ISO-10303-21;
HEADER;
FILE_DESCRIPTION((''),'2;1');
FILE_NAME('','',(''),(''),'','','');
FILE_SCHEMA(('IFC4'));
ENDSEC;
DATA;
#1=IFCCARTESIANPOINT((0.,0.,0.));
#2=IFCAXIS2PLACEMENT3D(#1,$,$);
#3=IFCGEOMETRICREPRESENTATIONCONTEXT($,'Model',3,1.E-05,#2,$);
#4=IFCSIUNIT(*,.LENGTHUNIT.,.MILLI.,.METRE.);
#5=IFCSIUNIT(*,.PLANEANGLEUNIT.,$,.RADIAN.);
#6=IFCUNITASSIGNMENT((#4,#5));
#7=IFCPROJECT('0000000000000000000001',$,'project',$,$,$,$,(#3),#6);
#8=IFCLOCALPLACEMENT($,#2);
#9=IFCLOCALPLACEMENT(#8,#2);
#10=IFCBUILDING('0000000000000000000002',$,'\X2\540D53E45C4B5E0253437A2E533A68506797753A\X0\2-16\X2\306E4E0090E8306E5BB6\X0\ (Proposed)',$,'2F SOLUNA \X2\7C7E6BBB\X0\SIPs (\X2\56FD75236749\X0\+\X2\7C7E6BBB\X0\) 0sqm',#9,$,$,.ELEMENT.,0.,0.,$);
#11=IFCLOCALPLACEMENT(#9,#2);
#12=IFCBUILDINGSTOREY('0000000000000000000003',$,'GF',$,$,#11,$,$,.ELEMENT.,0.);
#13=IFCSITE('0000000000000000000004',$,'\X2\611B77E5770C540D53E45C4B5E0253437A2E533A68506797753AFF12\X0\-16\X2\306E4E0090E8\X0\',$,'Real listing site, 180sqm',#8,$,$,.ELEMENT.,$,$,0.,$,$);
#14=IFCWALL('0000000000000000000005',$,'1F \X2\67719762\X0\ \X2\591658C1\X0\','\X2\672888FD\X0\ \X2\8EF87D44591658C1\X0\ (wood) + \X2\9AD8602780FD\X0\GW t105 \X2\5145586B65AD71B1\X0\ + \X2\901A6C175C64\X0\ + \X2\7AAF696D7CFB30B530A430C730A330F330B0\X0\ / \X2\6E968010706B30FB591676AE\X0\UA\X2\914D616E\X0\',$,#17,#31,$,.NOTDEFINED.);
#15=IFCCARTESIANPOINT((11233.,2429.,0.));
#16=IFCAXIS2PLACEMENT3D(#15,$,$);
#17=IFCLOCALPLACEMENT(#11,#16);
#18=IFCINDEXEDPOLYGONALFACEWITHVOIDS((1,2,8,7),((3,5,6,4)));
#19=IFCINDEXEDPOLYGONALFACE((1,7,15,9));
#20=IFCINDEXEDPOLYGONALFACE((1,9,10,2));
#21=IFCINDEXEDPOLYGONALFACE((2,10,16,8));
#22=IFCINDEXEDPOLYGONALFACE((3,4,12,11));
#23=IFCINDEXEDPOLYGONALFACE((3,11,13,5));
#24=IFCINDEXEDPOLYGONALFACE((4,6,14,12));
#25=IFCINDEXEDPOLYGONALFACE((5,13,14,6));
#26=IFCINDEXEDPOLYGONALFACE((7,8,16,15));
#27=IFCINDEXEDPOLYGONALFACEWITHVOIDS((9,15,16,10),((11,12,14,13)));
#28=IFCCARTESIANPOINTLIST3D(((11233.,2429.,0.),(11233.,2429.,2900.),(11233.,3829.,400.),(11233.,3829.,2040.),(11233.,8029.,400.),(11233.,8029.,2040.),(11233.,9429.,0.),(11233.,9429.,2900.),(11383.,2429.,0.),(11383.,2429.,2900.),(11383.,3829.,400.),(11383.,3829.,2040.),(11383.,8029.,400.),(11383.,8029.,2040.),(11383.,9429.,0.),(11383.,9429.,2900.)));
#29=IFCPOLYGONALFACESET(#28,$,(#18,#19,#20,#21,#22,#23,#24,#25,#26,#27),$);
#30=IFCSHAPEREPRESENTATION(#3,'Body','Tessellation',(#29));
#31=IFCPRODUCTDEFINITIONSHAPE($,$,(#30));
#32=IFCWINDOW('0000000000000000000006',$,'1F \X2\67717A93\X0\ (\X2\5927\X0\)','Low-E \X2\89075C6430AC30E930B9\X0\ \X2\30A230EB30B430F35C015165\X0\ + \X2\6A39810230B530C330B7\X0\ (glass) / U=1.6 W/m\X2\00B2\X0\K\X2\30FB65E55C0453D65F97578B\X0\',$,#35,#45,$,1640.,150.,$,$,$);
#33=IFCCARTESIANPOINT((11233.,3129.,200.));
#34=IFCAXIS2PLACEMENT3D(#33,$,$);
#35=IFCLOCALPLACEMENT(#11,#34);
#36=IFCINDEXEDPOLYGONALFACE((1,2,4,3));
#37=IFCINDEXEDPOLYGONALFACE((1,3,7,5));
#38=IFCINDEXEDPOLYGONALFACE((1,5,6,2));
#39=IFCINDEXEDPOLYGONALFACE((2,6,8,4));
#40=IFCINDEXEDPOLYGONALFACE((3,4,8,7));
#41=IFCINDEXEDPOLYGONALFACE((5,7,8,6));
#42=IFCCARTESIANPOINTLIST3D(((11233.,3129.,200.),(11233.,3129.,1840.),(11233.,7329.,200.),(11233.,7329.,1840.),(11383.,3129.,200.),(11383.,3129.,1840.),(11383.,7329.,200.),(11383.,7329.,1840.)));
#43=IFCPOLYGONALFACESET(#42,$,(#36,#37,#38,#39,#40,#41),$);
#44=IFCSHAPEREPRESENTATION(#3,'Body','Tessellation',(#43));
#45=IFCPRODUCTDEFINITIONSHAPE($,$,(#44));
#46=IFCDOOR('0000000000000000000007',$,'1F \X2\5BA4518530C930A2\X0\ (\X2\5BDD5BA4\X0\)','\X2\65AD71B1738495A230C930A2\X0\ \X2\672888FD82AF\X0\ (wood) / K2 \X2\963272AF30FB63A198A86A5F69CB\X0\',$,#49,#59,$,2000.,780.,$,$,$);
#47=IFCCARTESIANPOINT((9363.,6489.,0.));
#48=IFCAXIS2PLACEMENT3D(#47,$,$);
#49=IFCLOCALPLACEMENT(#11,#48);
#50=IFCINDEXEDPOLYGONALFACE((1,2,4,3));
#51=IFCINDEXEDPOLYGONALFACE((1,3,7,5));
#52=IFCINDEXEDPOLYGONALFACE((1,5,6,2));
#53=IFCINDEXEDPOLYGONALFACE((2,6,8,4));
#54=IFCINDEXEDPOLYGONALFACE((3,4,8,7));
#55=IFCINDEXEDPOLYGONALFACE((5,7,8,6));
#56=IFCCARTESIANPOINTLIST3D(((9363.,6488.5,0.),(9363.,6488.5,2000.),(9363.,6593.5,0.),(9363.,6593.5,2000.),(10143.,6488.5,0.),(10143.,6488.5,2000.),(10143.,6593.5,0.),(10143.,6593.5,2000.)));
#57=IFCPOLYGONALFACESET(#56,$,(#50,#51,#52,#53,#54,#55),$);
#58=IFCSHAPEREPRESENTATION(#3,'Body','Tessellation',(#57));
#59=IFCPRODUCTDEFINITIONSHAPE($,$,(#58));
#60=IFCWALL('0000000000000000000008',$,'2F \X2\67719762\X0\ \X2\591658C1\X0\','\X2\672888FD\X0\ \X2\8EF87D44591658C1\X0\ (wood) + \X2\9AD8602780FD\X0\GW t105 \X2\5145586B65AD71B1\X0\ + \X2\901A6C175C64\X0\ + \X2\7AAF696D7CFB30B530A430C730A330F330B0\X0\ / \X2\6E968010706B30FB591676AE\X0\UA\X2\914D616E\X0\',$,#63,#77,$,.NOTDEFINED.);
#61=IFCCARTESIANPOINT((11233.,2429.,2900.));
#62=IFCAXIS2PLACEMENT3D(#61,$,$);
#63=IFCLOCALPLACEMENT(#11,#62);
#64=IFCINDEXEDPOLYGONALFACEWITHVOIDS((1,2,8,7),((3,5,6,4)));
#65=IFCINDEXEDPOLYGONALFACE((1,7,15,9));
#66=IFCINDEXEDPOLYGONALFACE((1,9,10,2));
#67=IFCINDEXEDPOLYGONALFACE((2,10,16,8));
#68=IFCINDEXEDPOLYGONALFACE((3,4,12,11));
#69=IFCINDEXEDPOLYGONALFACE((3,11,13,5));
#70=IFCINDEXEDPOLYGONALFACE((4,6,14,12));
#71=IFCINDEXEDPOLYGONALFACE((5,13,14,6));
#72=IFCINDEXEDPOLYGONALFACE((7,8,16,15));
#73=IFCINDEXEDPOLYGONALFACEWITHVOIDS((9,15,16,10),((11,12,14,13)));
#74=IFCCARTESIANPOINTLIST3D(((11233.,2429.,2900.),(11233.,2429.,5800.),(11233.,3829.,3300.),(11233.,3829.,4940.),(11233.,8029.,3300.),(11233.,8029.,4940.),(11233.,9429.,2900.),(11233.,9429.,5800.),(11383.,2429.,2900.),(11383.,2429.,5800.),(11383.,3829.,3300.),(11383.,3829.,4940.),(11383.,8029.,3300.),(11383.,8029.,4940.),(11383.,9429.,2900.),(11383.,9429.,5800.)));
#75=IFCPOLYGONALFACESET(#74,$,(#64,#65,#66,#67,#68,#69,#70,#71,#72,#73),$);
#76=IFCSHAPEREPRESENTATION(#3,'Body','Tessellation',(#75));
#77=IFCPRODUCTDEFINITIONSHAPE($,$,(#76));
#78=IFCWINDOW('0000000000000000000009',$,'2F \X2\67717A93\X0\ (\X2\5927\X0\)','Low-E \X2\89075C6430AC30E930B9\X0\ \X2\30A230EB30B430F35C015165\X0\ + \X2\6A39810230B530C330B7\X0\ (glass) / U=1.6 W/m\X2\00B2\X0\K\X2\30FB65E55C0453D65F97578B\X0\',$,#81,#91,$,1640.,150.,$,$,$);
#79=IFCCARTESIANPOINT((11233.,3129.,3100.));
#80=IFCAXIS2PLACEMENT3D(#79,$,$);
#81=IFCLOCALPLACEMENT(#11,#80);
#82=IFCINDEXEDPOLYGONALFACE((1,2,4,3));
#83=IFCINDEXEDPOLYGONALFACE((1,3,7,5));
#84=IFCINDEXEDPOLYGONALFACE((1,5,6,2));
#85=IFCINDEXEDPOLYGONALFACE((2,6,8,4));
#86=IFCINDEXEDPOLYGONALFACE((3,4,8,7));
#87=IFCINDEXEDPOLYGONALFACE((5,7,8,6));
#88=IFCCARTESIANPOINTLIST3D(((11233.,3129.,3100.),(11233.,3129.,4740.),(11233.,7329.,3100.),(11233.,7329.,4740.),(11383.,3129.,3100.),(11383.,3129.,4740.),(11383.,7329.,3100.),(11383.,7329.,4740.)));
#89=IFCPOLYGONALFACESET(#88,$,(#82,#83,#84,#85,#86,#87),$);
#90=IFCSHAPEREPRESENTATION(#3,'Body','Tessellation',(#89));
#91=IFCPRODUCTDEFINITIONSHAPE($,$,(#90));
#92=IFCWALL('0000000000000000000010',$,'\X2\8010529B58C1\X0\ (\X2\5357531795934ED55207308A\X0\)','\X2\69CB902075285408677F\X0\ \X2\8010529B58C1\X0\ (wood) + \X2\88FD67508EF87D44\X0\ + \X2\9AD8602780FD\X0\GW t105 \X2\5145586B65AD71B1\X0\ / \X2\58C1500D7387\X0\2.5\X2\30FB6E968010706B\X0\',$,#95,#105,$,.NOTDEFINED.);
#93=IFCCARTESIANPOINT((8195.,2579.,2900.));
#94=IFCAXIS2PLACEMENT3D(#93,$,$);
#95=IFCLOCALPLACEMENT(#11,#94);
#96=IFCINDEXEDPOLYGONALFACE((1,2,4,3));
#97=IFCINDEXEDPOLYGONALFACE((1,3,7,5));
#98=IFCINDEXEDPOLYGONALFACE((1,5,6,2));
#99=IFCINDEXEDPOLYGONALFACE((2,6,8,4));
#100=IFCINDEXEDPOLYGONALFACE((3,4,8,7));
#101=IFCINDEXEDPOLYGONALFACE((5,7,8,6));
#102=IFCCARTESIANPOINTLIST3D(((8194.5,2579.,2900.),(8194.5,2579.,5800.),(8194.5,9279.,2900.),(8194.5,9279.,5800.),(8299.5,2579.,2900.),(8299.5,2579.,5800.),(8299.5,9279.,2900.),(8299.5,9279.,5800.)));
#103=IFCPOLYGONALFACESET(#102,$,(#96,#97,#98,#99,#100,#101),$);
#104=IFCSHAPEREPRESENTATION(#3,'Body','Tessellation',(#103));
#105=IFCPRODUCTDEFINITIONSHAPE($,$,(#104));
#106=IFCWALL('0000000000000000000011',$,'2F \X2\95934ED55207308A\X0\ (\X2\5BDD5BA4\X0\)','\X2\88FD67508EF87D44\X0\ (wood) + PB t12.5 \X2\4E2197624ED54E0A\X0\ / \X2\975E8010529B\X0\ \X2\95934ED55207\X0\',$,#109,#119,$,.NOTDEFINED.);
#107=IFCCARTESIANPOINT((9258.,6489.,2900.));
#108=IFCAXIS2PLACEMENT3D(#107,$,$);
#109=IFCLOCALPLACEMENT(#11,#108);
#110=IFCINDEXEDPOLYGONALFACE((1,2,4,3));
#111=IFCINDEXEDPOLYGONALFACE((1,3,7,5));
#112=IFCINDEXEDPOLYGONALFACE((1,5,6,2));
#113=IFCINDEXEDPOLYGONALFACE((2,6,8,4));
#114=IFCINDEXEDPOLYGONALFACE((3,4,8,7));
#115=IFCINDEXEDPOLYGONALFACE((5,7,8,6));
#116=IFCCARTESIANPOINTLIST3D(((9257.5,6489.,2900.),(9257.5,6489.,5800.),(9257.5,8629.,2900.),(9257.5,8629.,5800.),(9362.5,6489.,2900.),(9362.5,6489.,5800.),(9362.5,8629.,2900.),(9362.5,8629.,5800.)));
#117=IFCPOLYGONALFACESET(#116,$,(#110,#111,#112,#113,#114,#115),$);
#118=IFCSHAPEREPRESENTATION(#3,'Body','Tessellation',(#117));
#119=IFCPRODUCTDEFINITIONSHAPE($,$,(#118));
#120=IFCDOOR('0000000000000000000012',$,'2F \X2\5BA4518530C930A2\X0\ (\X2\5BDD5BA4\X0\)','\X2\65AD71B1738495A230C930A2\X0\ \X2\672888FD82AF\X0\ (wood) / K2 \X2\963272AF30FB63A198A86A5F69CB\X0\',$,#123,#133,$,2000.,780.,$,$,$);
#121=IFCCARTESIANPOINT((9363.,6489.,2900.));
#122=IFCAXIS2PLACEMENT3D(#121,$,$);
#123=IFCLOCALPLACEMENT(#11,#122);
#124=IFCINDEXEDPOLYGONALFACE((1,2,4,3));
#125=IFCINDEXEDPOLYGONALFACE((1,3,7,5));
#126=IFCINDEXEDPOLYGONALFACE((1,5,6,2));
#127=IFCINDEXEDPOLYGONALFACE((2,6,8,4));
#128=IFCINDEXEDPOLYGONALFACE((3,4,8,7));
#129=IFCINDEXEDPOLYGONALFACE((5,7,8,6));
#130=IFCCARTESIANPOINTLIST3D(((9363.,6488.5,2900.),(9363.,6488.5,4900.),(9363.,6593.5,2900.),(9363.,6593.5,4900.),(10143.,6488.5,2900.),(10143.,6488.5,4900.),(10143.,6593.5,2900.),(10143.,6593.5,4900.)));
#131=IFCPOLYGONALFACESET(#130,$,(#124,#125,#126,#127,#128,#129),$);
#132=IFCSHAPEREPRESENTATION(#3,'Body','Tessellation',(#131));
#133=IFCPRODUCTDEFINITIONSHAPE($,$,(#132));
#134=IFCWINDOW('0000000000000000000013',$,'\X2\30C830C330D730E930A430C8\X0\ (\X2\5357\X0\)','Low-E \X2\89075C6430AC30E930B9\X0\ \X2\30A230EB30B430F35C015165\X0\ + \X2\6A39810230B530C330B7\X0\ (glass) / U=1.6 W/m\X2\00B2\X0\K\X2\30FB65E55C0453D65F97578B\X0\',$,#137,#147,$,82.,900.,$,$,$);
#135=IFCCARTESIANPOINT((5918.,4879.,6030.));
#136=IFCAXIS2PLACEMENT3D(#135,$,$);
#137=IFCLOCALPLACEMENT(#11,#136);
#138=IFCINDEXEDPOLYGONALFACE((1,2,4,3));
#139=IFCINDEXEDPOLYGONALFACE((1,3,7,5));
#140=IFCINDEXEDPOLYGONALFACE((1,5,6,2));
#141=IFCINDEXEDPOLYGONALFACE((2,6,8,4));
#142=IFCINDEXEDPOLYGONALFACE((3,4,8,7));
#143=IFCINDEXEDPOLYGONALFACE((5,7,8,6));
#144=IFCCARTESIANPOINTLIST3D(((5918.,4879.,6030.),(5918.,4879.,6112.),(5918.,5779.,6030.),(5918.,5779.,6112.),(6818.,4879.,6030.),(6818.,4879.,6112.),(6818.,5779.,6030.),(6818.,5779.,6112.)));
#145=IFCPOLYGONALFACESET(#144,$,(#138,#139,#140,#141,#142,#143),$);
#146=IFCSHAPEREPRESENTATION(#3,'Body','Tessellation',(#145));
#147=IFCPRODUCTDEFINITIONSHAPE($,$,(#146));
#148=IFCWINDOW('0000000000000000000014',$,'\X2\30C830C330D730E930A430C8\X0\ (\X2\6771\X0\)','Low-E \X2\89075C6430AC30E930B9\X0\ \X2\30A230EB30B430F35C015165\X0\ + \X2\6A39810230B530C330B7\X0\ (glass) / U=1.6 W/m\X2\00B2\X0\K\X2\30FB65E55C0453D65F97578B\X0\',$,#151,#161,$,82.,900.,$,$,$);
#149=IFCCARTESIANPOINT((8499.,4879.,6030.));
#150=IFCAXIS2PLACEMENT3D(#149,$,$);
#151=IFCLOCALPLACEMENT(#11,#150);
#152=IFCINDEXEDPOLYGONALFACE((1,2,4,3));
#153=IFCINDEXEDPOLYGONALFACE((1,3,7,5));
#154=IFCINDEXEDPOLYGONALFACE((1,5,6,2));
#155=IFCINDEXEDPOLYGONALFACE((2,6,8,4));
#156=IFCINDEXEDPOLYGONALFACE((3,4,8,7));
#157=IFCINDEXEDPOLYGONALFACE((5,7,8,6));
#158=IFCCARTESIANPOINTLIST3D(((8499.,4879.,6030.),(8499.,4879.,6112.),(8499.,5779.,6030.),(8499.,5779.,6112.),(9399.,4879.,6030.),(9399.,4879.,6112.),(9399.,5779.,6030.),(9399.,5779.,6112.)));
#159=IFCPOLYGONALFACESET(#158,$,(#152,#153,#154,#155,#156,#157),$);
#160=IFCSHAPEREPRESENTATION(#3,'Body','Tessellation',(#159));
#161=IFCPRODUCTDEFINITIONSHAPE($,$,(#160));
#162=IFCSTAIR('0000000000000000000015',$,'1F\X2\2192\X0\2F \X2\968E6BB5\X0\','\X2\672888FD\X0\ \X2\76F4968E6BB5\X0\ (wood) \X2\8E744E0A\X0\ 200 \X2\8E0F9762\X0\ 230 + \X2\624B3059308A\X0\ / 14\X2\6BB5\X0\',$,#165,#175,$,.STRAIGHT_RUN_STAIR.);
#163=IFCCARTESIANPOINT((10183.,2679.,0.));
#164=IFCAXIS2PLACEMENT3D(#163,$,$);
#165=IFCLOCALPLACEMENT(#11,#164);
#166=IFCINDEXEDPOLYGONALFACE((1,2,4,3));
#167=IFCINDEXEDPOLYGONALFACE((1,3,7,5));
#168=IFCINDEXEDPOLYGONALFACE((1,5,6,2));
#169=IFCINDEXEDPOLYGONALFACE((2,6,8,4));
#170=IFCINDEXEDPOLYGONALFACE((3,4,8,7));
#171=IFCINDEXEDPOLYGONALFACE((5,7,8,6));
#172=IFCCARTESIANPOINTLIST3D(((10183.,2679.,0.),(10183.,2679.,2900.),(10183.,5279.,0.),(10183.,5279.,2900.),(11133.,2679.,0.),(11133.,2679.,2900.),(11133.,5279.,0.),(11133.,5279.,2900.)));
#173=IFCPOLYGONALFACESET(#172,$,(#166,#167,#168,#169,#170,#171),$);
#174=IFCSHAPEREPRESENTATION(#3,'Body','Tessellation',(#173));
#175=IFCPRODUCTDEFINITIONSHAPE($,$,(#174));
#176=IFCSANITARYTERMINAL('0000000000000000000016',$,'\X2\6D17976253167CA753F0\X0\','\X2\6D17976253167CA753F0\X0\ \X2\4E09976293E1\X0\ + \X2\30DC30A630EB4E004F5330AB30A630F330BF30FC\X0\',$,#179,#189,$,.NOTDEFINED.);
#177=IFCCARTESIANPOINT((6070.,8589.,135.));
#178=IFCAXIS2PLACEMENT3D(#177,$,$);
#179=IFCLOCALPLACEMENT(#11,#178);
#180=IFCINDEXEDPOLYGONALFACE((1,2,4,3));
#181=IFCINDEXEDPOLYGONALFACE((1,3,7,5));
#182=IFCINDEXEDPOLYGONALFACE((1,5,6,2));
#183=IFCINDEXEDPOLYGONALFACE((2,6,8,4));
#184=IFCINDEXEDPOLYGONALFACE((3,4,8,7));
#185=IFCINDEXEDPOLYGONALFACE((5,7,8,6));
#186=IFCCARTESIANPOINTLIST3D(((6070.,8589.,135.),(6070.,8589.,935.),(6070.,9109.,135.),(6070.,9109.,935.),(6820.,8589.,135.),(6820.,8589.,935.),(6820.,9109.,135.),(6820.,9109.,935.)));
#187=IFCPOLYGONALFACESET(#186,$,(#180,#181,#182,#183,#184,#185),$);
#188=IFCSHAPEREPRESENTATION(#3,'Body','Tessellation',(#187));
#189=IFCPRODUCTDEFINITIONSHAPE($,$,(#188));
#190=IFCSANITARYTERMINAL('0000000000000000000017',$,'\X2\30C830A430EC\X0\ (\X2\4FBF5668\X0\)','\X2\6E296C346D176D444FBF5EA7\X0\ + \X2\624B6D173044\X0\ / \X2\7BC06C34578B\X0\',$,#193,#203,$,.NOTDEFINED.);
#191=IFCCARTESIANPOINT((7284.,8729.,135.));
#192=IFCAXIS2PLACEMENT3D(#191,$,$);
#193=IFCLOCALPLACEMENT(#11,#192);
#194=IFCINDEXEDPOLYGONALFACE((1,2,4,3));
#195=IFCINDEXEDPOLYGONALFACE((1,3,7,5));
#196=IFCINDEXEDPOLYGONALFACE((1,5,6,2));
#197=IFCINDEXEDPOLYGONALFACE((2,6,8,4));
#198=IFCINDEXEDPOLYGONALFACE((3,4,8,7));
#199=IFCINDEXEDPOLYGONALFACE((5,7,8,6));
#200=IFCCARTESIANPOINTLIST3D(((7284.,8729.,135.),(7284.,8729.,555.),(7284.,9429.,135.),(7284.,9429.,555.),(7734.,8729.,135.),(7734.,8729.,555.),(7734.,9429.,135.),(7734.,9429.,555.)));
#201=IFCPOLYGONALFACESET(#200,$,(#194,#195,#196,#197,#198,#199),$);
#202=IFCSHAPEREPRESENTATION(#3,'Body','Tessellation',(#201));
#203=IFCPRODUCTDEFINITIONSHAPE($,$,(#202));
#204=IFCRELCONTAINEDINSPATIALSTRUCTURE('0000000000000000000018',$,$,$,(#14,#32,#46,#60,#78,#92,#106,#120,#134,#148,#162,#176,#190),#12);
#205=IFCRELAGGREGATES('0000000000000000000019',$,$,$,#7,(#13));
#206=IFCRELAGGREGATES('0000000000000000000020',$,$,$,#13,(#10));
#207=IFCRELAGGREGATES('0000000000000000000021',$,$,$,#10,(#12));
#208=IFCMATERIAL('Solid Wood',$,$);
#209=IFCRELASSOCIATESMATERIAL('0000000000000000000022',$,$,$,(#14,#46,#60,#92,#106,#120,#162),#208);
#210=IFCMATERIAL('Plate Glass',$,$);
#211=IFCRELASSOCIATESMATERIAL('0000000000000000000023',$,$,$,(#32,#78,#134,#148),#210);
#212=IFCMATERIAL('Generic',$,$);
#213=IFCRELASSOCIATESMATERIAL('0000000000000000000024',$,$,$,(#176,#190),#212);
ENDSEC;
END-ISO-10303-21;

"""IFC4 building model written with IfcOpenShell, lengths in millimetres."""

from ifc_helpers import new_model, si_unit, frame, frame_2d, origin, place, context, project, spatial, rectangle, extrude, material, element, fill, save


model = new_model("IFC4")

# Units and contexts
model_context = context("Model", 3, precision=1e-05, world=origin())
ifc_project = project(units=[si_unit("LENGTHUNIT", "METRE", prefix="MILLI"), si_unit("PLANEANGLEUNIT", "RADIAN")], contexts=[model_context])

# Site, building, storey
site_placement = place(None, origin())
site = spatial("IfcSite", under=ifc_project, at=site_placement, Name="愛知県名古屋市千種区桐林町２-16の一部", ObjectType="Real listing site, 180sqm", CompositionType="ELEMENT", RefElevation=0.0)
building_placement = place(site_placement, origin())
building = spatial("IfcBuilding", under=site, at=building_placement, Name="名古屋市千種区桐林町2-16の一部の家 (Proposed)", ObjectType="2F SOLUNA 籾殻SIPs (国産杉+籾殻) 0sqm", CompositionType="ELEMENT", ElevationOfRefHeight=0.0, ElevationOfTerrain=0.0)
storey_placement = place(building_placement, origin())
storey = spatial("IfcBuildingStorey", under=building, at=storey_placement, Name="GF", CompositionType="ELEMENT", Elevation=0.0)

# Wall, opening, window
ifc_material_1 = material(Name="Solid Wood")
wall_1_placement = place(storey_placement, frame((11233.0, 2429.0, 0.0)))
wall_1 = element("IfcWall", 1, at=wall_1_placement, inside=storey, material=ifc_material_1, Name="1F 東面 外壁", Description="木製 軸組外壁 (wood) + 高性能GW t105 充填断熱 + 通気層 + 窯業系サイディング / 準耐火・外皮UA配慮", PredefinedType="NOTDEFINED", context=model_context, shape_type="SweptSolid", body=[
    extrude(rectangle(XDim=150.0, YDim=7000.0, at=frame_2d((75.0, 3500.0))), frame((11233.0, 2429.0, 0.0)), (0.0, 0.0, 1.0), 2900.0),
])
opening_1_placement = place(storey_placement, frame((11233.0, 3129.0, 200.0)))
opening_1 = element("IfcOpeningElement", 2, at=opening_1_placement, cuts=wall_1, PredefinedType="NOTDEFINED", context=model_context, shape_type="SweptSolid", body=[
    extrude(rectangle(XDim=150.0, YDim=4200.0, at=frame_2d((75.0, 2100.0))), frame((11233.0, 3129.0, 200.0)), (0.0, 0.0, 1.0), 1640.0),
])
ifc_material_2 = material(Name="Plate Glass")
window_1_placement = place(storey_placement, frame((11233.0, 3129.0, 200.0)))
window_1 = element("IfcWindow", 3, at=window_1_placement, inside=storey, material=ifc_material_2, Name="1F 東窓 (大)", Description="Low-E 複層ガラス アルゴン封入 + 樹脂サッシ (glass) / U=1.6 W/m²K・日射取得型", OverallHeight=1640.0, OverallWidth=150.0, context=model_context, shape_type="SweptSolid", body=[
    extrude(rectangle(XDim=150.0, YDim=4200.0, at=frame_2d((75.0, 2100.0))), frame((11233.0, 3129.0, 200.0)), (0.0, 0.0, 1.0), 1640.0),
])
fill(opening_1, window_1)

# Door
door_1_placement = place(storey_placement, frame((9363.0, 6489.0, 0.0)))
element("IfcDoor", 4, at=door_1_placement, inside=storey, material=ifc_material_1, Name="1F 室内ドア (寝室)", Description="断熱玄関ドア 木製芯 (wood) / K2 防犯・採風機構", OverallHeight=2000.0, OverallWidth=780.0, context=model_context, shape_type="SweptSolid", body=[
    extrude(rectangle(XDim=780.0, YDim=105.0, at=frame_2d((390.0, 52.0))), frame((9363.0, 6489.0, 0.0)), (0.0, 0.0, 1.0), 2000.0),
])

# Wall, opening, window
wall_2_placement = place(storey_placement, frame((11233.0, 2429.0, 2900.0)))
wall_2 = element("IfcWall", 5, at=wall_2_placement, inside=storey, material=ifc_material_1, Name="2F 東面 外壁", Description="木製 軸組外壁 (wood) + 高性能GW t105 充填断熱 + 通気層 + 窯業系サイディング / 準耐火・外皮UA配慮", PredefinedType="NOTDEFINED", context=model_context, shape_type="SweptSolid", body=[
    extrude(rectangle(XDim=150.0, YDim=7000.0, at=frame_2d((75.0, 3500.0))), frame((11233.0, 2429.0, 2900.0)), (0.0, 0.0, 1.0), 2900.0),
])
opening_2_placement = place(storey_placement, frame((11233.0, 3129.0, 3100.0)))
opening_2 = element("IfcOpeningElement", 6, at=opening_2_placement, cuts=wall_2, PredefinedType="NOTDEFINED", context=model_context, shape_type="SweptSolid", body=[
    extrude(rectangle(XDim=150.0, YDim=4200.0, at=frame_2d((75.0, 2100.0))), frame((11233.0, 3129.0, 3100.0)), (0.0, 0.0, 1.0), 1640.0),
])
window_2_placement = place(storey_placement, frame((11233.0, 3129.0, 3100.0)))
window_2 = element("IfcWindow", 7, at=window_2_placement, inside=storey, material=ifc_material_2, Name="2F 東窓 (大)", Description="Low-E 複層ガラス アルゴン封入 + 樹脂サッシ (glass) / U=1.6 W/m²K・日射取得型", OverallHeight=1640.0, OverallWidth=150.0, context=model_context, shape_type="SweptSolid", body=[
    extrude(rectangle(XDim=150.0, YDim=4200.0, at=frame_2d((75.0, 2100.0))), frame((11233.0, 3129.0, 3100.0)), (0.0, 0.0, 1.0), 1640.0),
])
fill(opening_2, window_2)

# Walls
wall_3_placement = place(storey_placement, frame((8195.0, 2579.0, 2900.0)))
element("IfcWall", 8, at=wall_3_placement, inside=storey, material=ifc_material_1, Name="耐力壁 (南北間仕切り)", Description="構造用合板 耐力壁 (wood) + 製材軸組 + 高性能GW t105 充填断熱 / 壁倍率2.5・準耐火", PredefinedType="NOTDEFINED", context=model_context, shape_type="SweptSolid", body=[
    extrude(rectangle(XDim=105.0, YDim=6700.0, at=frame_2d((52.0, 3350.0))), frame((8195.0, 2579.0, 2900.0)), (0.0, 0.0, 1.0), 2900.0),
])
wall_4_placement = place(storey_placement, frame((9258.0, 6489.0, 2900.0)))
element("IfcWall", 9, at=wall_4_placement, inside=storey, material=ifc_material_1, Name="2F 間仕切り (寝室)", Description="製材軸組 (wood) + PB t12.5 両面仕上 / 非耐力 間仕切", PredefinedType="NOTDEFINED", context=model_context, shape_type="SweptSolid", body=[
    extrude(rectangle(XDim=105.0, YDim=2140.0, at=frame_2d((52.0, 1070.0))), frame((9258.0, 6489.0, 2900.0)), (0.0, 0.0, 1.0), 2900.0),
])

# Door
door_2_placement = place(storey_placement, frame((9363.0, 6489.0, 2900.0)))
element("IfcDoor", 10, at=door_2_placement, inside=storey, material=ifc_material_1, Name="2F 室内ドア (寝室)", Description="断熱玄関ドア 木製芯 (wood) / K2 防犯・採風機構", OverallHeight=2000.0, OverallWidth=780.0, context=model_context, shape_type="SweptSolid", body=[
    extrude(rectangle(XDim=780.0, YDim=105.0, at=frame_2d((390.0, 52.0))), frame((9363.0, 6489.0, 2900.0)), (0.0, 0.0, 1.0), 2000.0),
])

# Windows
window_3_placement = place(storey_placement, frame((5918.0, 4879.0, 6030.0)))
element("IfcWindow", 11, at=window_3_placement, inside=storey, material=ifc_material_2, Name="トップライト (南)", Description="Low-E 複層ガラス アルゴン封入 + 樹脂サッシ (glass) / U=1.6 W/m²K・日射取得型", OverallHeight=82.0, OverallWidth=900.0, context=model_context, shape_type="SweptSolid", body=[
    extrude(rectangle(XDim=900.0, YDim=900.0, at=frame_2d((450.0, 450.0))), frame((5918.0, 4879.0, 6030.0)), (0.0, 0.0, 1.0), 82.0),
])
window_4_placement = place(storey_placement, frame((8499.0, 4879.0, 6030.0)))
element("IfcWindow", 12, at=window_4_placement, inside=storey, material=ifc_material_2, Name="トップライト (東)", Description="Low-E 複層ガラス アルゴン封入 + 樹脂サッシ (glass) / U=1.6 W/m²K・日射取得型", OverallHeight=82.0, OverallWidth=900.0, context=model_context, shape_type="SweptSolid", body=[
    extrude(rectangle(XDim=900.0, YDim=900.0, at=frame_2d((450.0, 450.0))), frame((8499.0, 4879.0, 6030.0)), (0.0, 0.0, 1.0), 82.0),
])

# Stair
stair_placement = place(storey_placement, frame((10183.0, 2679.0, 0.0)))
element("IfcStair", 13, at=stair_placement, inside=storey, material=ifc_material_1, Name="1F→2F 階段", Description="木製 直階段 (wood) 蹴上 200 踏面 230 + 手すり / 14段", PredefinedType="STRAIGHT_RUN_STAIR", context=model_context, shape_type="SweptSolid", body=[
    extrude(rectangle(XDim=950.0, YDim=2600.0, at=frame_2d((475.0, 1300.0))), frame((10183.0, 2679.0, 0.0)), (0.0, 0.0, 1.0), 2900.0),
])

# Sanitary terminals
ifc_material_3 = material(Name="Generic")
sanitary_terminal_1_placement = place(storey_placement, frame((6070.0, 8589.0, 135.0)))
element("IfcSanitaryTerminal", 14, at=sanitary_terminal_1_placement, inside=storey, material=ifc_material_3, Name="洗面化粧台", Description="洗面化粧台 三面鏡 + ボウル一体カウンター", PredefinedType="NOTDEFINED", context=model_context, shape_type="SweptSolid", body=[
    extrude(rectangle(XDim=750.0, YDim=520.0, at=frame_2d((375.0, 260.0))), frame((6070.0, 8589.0, 135.0)), (0.0, 0.0, 1.0), 800.0),
])
sanitary_terminal_2_placement = place(storey_placement, frame((7284.0, 8729.0, 135.0)))
element("IfcSanitaryTerminal", 15, at=sanitary_terminal_2_placement, inside=storey, material=ifc_material_3, Name="トイレ (便器)", Description="温水洗浄便座 + 手洗い / 節水型", PredefinedType="NOTDEFINED", context=model_context, shape_type="SweptSolid", body=[
    extrude(rectangle(XDim=450.0, YDim=700.0, at=frame_2d((225.0, 350.0))), frame((7284.0, 8729.0, 135.0)), (0.0, 0.0, 1.0), 420.0),
])

save(model, "model.ifc")
